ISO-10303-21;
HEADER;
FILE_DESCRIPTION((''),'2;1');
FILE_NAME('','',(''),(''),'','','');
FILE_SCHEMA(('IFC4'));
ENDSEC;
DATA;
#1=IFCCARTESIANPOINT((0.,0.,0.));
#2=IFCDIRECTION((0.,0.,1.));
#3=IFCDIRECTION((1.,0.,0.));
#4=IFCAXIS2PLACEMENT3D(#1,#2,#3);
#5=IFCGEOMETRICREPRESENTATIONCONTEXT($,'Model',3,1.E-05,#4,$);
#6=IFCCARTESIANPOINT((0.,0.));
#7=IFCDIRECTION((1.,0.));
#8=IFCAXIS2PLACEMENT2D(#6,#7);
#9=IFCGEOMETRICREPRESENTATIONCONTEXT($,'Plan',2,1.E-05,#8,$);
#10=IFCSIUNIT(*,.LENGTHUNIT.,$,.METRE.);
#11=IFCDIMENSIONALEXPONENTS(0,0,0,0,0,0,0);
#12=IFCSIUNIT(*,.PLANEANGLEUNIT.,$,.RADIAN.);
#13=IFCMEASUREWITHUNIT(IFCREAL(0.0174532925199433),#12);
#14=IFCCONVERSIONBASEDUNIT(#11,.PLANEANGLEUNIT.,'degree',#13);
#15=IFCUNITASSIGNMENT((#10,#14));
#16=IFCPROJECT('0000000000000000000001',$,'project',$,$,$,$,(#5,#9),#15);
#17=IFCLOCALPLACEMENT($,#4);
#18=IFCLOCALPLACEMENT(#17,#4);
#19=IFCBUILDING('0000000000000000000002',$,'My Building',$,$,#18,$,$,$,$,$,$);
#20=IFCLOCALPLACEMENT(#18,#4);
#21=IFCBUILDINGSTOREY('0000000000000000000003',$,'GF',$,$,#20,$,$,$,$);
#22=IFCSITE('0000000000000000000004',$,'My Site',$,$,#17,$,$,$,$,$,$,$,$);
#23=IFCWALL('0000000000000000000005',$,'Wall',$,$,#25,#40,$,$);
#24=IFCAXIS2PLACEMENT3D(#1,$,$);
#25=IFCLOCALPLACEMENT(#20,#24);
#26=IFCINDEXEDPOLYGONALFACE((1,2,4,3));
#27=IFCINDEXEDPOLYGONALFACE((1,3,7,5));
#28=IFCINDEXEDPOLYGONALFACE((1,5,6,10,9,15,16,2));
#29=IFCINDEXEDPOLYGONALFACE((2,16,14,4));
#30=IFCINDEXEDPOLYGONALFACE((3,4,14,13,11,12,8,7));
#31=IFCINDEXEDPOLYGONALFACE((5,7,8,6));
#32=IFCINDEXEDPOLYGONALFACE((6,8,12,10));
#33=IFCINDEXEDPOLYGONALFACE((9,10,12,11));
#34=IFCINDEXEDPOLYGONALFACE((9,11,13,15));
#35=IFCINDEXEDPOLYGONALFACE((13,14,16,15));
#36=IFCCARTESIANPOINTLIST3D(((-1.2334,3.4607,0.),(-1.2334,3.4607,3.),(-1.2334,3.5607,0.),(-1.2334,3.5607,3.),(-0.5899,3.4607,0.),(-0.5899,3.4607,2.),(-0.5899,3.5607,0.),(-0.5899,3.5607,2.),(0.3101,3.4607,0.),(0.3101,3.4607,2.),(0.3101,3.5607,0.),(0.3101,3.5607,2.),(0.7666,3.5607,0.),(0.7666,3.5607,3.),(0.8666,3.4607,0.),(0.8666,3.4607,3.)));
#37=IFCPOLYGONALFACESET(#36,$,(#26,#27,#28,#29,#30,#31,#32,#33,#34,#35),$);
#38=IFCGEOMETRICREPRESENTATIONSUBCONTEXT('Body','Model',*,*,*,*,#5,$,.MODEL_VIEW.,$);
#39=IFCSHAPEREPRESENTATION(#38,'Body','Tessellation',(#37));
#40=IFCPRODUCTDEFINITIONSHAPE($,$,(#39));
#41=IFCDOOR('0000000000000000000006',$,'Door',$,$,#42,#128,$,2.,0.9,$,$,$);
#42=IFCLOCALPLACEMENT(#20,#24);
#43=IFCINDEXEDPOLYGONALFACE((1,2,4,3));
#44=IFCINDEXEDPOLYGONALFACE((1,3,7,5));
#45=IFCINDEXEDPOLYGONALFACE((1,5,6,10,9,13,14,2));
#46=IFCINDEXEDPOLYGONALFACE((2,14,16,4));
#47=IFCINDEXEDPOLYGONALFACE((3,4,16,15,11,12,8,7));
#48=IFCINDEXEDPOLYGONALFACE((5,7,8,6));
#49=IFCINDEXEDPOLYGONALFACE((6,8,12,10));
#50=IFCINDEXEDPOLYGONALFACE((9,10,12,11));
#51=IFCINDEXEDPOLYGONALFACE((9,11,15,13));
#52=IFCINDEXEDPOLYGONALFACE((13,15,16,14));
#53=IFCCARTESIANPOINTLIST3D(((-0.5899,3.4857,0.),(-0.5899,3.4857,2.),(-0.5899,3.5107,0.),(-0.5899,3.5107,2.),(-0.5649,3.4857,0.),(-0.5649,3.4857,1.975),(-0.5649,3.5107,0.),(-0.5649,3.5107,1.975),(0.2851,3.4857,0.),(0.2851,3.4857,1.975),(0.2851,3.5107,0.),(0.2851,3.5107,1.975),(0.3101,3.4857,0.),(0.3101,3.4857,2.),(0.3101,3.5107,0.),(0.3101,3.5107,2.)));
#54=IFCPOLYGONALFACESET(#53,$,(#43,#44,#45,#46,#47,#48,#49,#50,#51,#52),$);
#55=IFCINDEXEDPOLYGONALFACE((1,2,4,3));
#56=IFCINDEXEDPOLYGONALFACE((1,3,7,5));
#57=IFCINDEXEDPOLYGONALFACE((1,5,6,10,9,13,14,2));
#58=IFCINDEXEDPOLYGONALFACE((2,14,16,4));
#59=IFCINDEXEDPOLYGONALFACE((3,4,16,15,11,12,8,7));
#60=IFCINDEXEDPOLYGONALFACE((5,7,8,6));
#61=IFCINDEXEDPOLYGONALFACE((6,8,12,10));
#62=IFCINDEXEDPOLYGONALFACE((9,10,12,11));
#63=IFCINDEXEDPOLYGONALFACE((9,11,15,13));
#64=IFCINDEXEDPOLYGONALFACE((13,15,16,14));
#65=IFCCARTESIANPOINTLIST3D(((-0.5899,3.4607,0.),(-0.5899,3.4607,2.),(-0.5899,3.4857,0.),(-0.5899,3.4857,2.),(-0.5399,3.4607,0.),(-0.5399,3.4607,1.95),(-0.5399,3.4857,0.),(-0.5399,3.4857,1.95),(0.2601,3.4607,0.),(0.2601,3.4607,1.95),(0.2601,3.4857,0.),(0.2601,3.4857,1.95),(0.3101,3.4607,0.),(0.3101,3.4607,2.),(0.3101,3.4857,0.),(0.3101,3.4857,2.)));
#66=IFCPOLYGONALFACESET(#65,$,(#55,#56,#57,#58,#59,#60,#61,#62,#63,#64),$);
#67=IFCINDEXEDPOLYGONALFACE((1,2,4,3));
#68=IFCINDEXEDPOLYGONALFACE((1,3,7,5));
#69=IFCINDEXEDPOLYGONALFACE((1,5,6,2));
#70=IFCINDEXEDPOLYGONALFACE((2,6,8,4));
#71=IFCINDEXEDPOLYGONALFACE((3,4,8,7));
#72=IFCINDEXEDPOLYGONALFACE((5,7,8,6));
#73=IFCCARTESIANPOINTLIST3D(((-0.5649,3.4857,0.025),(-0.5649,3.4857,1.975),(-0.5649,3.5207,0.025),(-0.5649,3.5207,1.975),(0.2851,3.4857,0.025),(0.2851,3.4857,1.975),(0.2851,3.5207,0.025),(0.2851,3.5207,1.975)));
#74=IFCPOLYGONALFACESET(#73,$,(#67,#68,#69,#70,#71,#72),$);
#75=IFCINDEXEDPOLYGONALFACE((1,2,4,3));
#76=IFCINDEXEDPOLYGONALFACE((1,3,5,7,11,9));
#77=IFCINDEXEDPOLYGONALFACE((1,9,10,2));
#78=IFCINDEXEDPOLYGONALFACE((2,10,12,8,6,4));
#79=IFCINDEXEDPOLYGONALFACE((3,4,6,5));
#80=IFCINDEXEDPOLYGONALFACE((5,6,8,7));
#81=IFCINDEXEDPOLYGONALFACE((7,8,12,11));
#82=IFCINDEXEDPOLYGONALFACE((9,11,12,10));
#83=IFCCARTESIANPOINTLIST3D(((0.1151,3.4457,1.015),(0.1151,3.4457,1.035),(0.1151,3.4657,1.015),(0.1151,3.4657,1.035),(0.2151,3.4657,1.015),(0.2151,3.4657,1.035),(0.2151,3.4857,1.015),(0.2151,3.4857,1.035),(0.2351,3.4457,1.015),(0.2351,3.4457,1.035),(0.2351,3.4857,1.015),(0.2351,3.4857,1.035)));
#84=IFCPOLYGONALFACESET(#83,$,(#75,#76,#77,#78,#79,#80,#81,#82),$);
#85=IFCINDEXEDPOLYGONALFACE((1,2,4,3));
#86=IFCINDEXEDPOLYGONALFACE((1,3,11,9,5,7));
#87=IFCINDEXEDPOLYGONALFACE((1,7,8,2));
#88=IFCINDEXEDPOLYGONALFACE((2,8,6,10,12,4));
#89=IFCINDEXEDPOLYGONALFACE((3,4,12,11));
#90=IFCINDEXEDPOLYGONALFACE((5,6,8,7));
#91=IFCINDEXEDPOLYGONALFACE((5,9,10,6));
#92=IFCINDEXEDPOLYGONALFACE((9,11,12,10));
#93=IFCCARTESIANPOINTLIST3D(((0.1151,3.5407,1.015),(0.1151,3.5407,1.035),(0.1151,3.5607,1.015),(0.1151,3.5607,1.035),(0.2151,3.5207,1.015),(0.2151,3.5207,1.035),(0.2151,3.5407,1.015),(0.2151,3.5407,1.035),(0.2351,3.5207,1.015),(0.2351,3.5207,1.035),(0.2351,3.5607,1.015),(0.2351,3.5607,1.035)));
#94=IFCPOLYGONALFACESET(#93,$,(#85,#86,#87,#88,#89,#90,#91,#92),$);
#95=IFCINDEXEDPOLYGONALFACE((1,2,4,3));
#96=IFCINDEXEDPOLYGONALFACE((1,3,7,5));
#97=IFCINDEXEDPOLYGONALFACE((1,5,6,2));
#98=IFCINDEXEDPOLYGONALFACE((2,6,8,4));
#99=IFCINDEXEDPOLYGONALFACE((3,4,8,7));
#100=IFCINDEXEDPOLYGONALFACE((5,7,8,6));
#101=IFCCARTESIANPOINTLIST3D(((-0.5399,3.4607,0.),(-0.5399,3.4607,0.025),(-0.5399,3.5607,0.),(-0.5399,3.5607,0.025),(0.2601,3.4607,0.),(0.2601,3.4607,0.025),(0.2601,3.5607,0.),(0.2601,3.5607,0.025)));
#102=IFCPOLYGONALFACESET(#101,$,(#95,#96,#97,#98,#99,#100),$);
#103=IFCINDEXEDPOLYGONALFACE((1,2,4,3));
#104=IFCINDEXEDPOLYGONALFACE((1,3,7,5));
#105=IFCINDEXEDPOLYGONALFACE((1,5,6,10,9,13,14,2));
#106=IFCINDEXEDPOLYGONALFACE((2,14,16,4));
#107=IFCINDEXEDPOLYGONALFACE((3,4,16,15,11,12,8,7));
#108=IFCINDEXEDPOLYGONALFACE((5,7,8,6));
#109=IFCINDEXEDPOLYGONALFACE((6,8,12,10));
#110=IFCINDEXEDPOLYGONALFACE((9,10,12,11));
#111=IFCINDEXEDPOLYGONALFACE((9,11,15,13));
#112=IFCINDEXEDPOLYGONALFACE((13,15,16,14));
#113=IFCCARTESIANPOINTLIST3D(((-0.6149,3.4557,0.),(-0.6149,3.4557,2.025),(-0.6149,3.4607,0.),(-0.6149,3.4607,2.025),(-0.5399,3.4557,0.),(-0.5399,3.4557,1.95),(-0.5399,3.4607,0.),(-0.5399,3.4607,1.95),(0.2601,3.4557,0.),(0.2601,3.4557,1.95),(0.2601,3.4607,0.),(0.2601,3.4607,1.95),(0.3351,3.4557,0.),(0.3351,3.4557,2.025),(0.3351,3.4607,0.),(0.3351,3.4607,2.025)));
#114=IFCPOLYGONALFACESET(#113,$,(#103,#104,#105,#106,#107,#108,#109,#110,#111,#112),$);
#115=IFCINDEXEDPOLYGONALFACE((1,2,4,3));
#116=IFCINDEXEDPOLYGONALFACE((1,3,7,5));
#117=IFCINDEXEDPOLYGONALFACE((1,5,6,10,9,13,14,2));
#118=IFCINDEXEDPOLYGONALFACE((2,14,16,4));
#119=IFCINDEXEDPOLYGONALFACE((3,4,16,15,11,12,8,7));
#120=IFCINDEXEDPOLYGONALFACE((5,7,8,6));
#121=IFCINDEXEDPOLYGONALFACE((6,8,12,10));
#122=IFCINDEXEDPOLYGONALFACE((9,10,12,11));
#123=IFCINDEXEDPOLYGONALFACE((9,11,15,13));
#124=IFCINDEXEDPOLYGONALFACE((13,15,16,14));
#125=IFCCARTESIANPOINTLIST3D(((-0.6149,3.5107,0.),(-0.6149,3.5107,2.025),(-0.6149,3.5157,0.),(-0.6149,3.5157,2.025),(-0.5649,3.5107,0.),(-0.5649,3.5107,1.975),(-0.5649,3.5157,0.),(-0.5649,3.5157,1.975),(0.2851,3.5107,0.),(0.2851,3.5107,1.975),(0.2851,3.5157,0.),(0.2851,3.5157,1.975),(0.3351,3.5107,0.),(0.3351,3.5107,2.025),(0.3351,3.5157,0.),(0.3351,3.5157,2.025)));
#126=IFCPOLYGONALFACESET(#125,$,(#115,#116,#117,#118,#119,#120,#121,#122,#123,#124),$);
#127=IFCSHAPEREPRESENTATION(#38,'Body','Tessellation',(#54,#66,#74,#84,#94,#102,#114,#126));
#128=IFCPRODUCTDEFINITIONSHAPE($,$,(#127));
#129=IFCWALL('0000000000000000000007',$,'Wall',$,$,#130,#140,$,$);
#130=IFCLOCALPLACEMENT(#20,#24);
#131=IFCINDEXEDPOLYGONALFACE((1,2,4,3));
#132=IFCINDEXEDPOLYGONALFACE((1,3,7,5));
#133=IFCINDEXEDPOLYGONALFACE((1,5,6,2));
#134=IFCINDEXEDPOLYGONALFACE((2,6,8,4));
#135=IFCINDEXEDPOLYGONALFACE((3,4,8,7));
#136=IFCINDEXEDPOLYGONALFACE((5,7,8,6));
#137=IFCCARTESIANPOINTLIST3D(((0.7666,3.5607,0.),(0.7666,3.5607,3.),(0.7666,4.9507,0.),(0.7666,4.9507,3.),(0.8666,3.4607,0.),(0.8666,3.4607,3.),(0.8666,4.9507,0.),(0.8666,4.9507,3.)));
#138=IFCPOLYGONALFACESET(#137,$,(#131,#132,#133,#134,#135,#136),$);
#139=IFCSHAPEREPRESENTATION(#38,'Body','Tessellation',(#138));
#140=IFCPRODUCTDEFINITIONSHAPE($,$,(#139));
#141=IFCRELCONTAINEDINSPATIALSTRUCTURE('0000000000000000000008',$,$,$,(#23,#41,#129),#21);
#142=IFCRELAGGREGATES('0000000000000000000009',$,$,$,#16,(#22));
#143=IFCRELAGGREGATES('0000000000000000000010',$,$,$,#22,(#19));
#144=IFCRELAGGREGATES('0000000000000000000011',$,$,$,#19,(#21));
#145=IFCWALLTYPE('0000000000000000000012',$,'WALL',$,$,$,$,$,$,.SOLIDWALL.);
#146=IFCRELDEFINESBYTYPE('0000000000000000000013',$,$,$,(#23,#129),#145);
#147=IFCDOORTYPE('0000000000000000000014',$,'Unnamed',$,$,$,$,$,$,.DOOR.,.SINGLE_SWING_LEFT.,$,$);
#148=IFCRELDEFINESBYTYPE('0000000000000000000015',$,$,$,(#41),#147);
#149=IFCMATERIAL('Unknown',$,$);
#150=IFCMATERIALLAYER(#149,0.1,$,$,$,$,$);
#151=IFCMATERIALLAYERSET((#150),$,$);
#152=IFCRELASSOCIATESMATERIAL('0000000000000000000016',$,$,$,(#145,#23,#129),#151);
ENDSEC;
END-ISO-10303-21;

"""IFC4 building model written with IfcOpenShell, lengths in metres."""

from ifc_helpers import new_model, entity, si_unit, converted_unit, frame, origin_with_axes, origin_2d_with_axis, place, context, subcontext, project, spatial, line, indexed_curve, outline, extrude, shape, source, transform, mapped, material, layer, layer_set, layer_usage, type_object, type_shapes, element, fill, save


model = new_model("IFC4")

# Units and contexts
model_context = context("Model", 3, precision=1e-05, world=origin_with_axes())
plan_context = context("Plan", 2, precision=1e-05, world=origin_2d_with_axis())
body_context_1 = subcontext(model_context, "Body", "Model", "MODEL_VIEW")
body_context_2 = subcontext(plan_context, "Body", "Plan", "PLAN_VIEW")
ifc_project = project(units=[si_unit("LENGTHUNIT", "METRE"), converted_unit("PLANEANGLEUNIT", "degree", entity("IfcReal", 0.0174532925199433), si_unit("PLANEANGLEUNIT", "RADIAN"), dimensions=[0, 0, 0, 0, 0, 0, 0])], contexts=[model_context, plan_context])

# Site, building, storey
site_placement = place(None, origin_with_axes())
site = spatial("IfcSite", under=ifc_project, at=site_placement, Name="My Site")
building_placement = place(site_placement, origin_with_axes())
building = spatial("IfcBuilding", under=site, at=building_placement, Name="My Building")
storey_placement = place(building_placement, origin_with_axes())
storey = spatial("IfcBuildingStorey", under=building, at=storey_placement, Name="GF")

# Shared definitions
ifc_material = material(Name="Unknown")
ifc_layer = layer(ifc_material, 0.1)
ifc_layer_set = layer_set([ifc_layer])
wall_type = type_object("IfcWallType", Name="WALL", PredefinedType="SOLIDWALL", material=ifc_layer_set)

# Wall, opening, door
shared_shape_1 = source(origin_with_axes(), body_context_1, "Body", "SweptSolid", [
    extrude(outline(indexed_curve([(0.0, 0.0), (0.9, 0.0), (0.9, 2.0), (0.0, 2.0)], segments=[line(1, 2, 3, 4, 1)])), frame((0.0, -0.6, 0.0), z_axis=(0.0, -1.0, 0.0), x_axis=(1.0, 0.0, 0.0)), (0.0, 0.0, -1.0), 1.2),
])
door_type = type_object("IfcDoorType", Name="Unnamed", OperationType="SINGLE_SWING_LEFT", PredefinedType="DOOR")
shared_shape_2 = source(origin_with_axes(), body_context_1, "Body", "SweptSolid", [
    extrude(outline(indexed_curve([(0.0, 0.0), (0.0, 2.0), (0.9, 2.0), (0.9, 0.0), (0.875, 0.0), (0.875, 1.975), (0.025, 1.975), (0.025, 0.0)], segments=[line(1, 2, 3, 4, 5, 6, 7, 8, 1)])), frame((0.0, 0.025, 0.0), z_axis=(0.0, -1.0, 0.0), x_axis=(1.0, 0.0, 0.0)), (0.0, 0.0, -1.0), 0.025),
    extrude(outline(indexed_curve([(0.0, 0.0), (0.0, 2.0), (0.9, 2.0), (0.9, 0.0), (0.85, 0.0), (0.85, 1.95), (0.05, 1.95), (0.05, 0.0)], segments=[line(1, 2, 3, 4, 5, 6, 7, 8, 1)])), frame((0.0, 0.0, 0.0), z_axis=(0.0, -1.0, 0.0), x_axis=(1.0, 0.0, 0.0)), (0.0, 0.0, -1.0), 0.025),
    extrude(outline(indexed_curve([(0.0, 0.0), (0.85, 0.0), (0.85, 0.035), (0.0, 0.035)], segments=[line(1, 2, 3, 4, 1)])), frame((0.025, 0.025, 0.025), z_axis=(0.0, 0.0, 1.0), x_axis=(1.0, 0.0, 0.0)), (0.0, 0.0, 1.0), 1.95),
    extrude(outline(indexed_curve([(0.0, 0.0), (0.0, -0.04), (-0.12, -0.04), (-0.12, -0.02), (-0.02, -0.02), (-0.02, 0.0)], segments=[line(1, 2, 3, 4, 5, 6, 1)])), frame((0.825, 0.025, 1.015), z_axis=(0.0, 0.0, 1.0), x_axis=(1.0, 0.0, 0.0)), (0.0, 0.0, 1.0), 0.02),
    extrude(outline(indexed_curve([(0.0, 0.0), (0.0, 0.04), (-0.12, 0.04), (-0.12, 0.02), (-0.02, 0.02), (-0.02, 0.0)], segments=[line(1, 2, 3, 4, 5, 6, 1)])), frame((0.825, 0.06, 1.015), z_axis=(0.0, 0.0, 1.0), x_axis=(1.0, 0.0, 0.0)), (0.0, 0.0, 1.0), 0.02),
    extrude(outline(indexed_curve([(0.0, 0.0), (0.8, 0.0), (0.8, 0.1), (0.0, 0.1)], segments=[line(1, 2, 3, 4, 1)])), frame((0.05, 0.0, 0.0), z_axis=(0.0, 0.0, 1.0), x_axis=(1.0, 0.0, 0.0)), (0.0, 0.0, 1.0), 0.025),
    extrude(outline(indexed_curve([(0.0, 0.0), (0.0, 2.025), (0.95, 2.025), (0.95, 0.0), (0.875, 0.0), (0.875, 1.95), (0.075, 1.95), (0.075, 0.0)], segments=[line(1, 2, 3, 4, 5, 6, 7, 8, 1)])), frame((-0.025, -0.005, 0.0), z_axis=(0.0, -1.0, 0.0), x_axis=(1.0, 0.0, 0.0)), (0.0, 0.0, -1.0), 0.005),
    extrude(outline(indexed_curve([(0.0, 0.0), (0.0, 2.025), (0.95, 2.025), (0.95, 0.0), (0.9, 0.0), (0.9, 1.975), (0.05, 1.975), (0.05, 0.0)], segments=[line(1, 2, 3, 4, 5, 6, 7, 8, 1)])), frame((-0.025, 0.05, 0.0), z_axis=(0.0, -1.0, 0.0), x_axis=(1.0, 0.0, 0.0)), (0.0, 0.0, -1.0), 0.005),
])
shared_shape_3 = source(origin_with_axes(), body_context_2, "Body", "Curve2D", [
    entity("IfcIndexedPolyCurve", entity("IfcCartesianPointList2D", [[0.0, 0.0], [0.0, 0.05], [0.025, 0.05], [0.025, 0.025], [0.05, 0.025], [0.05, 0.0]]), [entity("IfcLineIndex", [1, 2, 3, 4, 5, 6, 1])]),
    entity("IfcIndexedPolyCurve", entity("IfcCartesianPointList2D", [[0.9, 0.0], [0.9, 0.05], [0.875, 0.05], [0.875, 0.025], [0.85, 0.025], [0.85, 0.0]]), [entity("IfcLineIndex", [1, 2, 3, 4, 5, 6, 1])]),
    entity("IfcTrimmedCurve", entity("IfcEllipse", entity("IfcAxis2Placement2D", entity("IfcCartesianPoint", [0.06, 0.05]), entity("IfcDirection", [1.0, 0.0])), 0.815, 0.85), [entity("IfcCartesianPoint", [0.875, 0.05])], [entity("IfcCartesianPoint", [0.06, 0.9])], True, "CARTESIAN"),
    entity("IfcIndexedPolyCurve", entity("IfcCartesianPointList2D", [[0.025, 0.05], [0.06, 0.05], [0.06, 0.9], [0.025, 0.9]]), [entity("IfcLineIndex", [1, 2, 3, 4, 1])]),
])
type_shapes(door_type, [shared_shape_2, shared_shape_3])
ifc_layer_usage_1 = layer_usage(ifc_layer_set, "AXIS2", "POSITIVE", 0.0)
wall_1_placement = place(storey_placement, frame((-1.2334, 3.4607, 0.0), z_axis=(0.0, 0.0, 1.0), x_axis=(1.0, 0.0, 0.0)))
wall_1 = element("IfcWall", 1, at=wall_1_placement, inside=storey, type_object=wall_type, material=ifc_layer_usage_1, Name="Wall", context=body_context_1, shape_type="SweptSolid", body=[
    extrude(outline(indexed_curve([(0.0, 0.0), (0.0, 0.1), (2.0, 0.1), (2.1, 0.0)], segments=[line(1, 2, 3, 4, 1)])), origin_with_axes(), (0.0, 0.0, 1.0), 3.0),
])
opening_1_placement = place(wall_1_placement, frame((0.6435, 0.0, 0.0), z_axis=(0.0, 0.0, 1.0), x_axis=(1.0, 0.0, 0.0)))
opening_1 = element("IfcOpeningElement", 2, at=opening_1_placement, cuts=wall_1, PredefinedType="OPENING", context=body_context_1, shape_type="MappedRepresentation", body=[
    mapped(shared_shape_1, transform((0.0, 0.0, 0.0), x_axis=(1.0, 0.0, 0.0), y_axis=(0.0, 1.0, 0.0), z_axis=(0.0, 0.0, 1.0), scale=1.0)),
])
door_1_placement = place(opening_1_placement, origin_with_axes())
door_1 = element("IfcDoor", 3, at=door_1_placement, inside=storey, type_object=door_type, Name="Door", OverallHeight=2.0, OverallWidth=0.9, shapes=[
    shape(body_context_1, "Body", "MappedRepresentation", [mapped(shared_shape_2, transform((0.0, 0.0, 0.0), x_axis=(1.0, 0.0, 0.0), y_axis=(0.0, 1.0, 0.0), z_axis=(0.0, 0.0, 1.0), scale=1.0))]),
    shape(body_context_2, "Body", "MappedRepresentation", [mapped(shared_shape_3, transform((0.0, 0.0, 0.0), x_axis=(1.0, 0.0, 0.0), y_axis=(0.0, 1.0, 0.0), z_axis=(0.0, 0.0, 1.0), scale=1.0))]),
])
fill(opening_1, door_1)

# Wall
ifc_layer_usage_2 = layer_usage(ifc_layer_set, "AXIS2", "POSITIVE", 0.0)
wall_2_placement = place(storey_placement, frame((0.8666, 3.4607, 0.0), z_axis=(0.0, 0.0, 1.0), x_axis=(0.0, 1.0, 0.0)))
element("IfcWall", 4, at=wall_2_placement, inside=storey, type_object=wall_type, material=ifc_layer_usage_2, Name="Wall", context=body_context_1, shape_type="SweptSolid", body=[
    extrude(outline(indexed_curve([(0.0, 0.0), (0.1, 0.1), (1.49, 0.1), (1.49, 0.0)], segments=[line(1, 2, 3, 4, 1)])), origin_with_axes(), (0.0, 0.0, 1.0), 3.0),
])

save(model, "model.ifc")
